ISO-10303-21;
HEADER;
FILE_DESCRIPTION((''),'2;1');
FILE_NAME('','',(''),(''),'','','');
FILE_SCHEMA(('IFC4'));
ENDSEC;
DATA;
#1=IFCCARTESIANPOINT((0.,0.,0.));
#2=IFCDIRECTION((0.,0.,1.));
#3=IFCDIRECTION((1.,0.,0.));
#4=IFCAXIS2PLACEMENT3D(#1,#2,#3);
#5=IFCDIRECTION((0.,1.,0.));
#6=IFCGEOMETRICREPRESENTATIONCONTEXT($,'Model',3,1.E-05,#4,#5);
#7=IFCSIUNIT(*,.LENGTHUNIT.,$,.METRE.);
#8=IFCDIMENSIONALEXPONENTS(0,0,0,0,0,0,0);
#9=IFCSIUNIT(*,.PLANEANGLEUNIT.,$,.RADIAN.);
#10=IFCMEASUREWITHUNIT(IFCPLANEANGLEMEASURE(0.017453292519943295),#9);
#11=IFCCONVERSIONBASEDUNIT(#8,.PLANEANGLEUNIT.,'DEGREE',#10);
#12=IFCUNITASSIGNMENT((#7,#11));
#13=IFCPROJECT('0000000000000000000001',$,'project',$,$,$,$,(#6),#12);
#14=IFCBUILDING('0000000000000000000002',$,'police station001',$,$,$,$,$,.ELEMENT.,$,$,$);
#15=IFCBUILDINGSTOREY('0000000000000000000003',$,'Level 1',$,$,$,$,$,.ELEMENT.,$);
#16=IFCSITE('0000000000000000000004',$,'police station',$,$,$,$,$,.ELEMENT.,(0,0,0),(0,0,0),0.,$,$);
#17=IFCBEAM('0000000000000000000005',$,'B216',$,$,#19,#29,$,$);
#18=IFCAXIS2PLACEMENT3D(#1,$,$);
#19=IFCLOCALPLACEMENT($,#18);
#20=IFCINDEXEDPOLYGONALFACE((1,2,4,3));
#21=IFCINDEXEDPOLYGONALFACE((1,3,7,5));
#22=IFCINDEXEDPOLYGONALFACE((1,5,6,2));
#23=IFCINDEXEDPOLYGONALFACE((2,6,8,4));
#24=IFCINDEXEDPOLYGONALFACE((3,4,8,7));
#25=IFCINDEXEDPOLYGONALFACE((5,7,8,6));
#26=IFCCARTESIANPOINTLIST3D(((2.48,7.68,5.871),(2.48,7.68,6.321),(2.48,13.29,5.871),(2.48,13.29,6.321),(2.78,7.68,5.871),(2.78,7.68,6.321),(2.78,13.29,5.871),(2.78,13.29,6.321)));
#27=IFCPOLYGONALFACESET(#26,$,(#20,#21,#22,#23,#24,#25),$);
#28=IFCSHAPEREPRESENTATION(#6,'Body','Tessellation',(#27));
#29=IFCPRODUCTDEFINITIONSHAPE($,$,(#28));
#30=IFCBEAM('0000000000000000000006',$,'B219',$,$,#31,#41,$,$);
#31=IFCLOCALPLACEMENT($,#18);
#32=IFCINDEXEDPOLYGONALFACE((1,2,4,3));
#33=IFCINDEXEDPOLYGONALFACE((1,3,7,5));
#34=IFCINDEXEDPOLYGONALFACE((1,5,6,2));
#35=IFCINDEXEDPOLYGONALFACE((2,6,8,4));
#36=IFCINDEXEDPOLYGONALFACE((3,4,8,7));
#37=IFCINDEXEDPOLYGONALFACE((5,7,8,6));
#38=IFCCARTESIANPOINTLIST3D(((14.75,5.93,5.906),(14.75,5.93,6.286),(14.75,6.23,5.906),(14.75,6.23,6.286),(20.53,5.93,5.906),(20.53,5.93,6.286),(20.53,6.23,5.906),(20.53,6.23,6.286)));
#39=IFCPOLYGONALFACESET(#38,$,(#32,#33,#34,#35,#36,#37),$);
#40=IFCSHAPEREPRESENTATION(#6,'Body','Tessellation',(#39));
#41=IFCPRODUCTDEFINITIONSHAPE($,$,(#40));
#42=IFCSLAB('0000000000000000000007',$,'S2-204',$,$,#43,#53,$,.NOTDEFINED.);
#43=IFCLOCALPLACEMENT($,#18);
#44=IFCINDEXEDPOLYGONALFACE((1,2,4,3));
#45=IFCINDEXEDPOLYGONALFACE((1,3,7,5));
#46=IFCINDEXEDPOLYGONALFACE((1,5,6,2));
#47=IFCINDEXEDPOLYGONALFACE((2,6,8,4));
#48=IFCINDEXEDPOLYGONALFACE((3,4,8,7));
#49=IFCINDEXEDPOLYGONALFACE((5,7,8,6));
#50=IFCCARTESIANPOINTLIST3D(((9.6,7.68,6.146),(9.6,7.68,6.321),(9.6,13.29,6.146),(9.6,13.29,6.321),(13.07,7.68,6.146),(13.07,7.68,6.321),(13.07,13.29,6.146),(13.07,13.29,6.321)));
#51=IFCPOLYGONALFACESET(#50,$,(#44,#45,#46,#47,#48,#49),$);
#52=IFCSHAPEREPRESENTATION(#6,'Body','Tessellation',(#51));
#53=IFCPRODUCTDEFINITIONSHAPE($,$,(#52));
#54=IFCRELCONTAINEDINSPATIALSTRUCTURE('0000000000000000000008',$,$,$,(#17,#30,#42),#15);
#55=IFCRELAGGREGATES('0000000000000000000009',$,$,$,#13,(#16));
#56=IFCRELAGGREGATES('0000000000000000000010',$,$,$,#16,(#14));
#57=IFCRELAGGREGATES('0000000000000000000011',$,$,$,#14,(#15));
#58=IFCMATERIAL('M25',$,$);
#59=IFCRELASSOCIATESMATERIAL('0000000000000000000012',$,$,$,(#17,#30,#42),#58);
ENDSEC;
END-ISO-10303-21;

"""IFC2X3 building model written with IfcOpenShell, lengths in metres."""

from ifc_helpers import new_model, entity, si_unit, converted_unit, direction, frame, frame_2d, origin_with_axes, place, context, project, spatial, rectangle, extrude, material, element, save


model = new_model("IFC2X3")

# Units and contexts
model_context = context("Model", 3, precision=1e-05, world=origin_with_axes(), true_north=direction((0.0, 1.0, 0.0)))
ifc_project = project(units=[si_unit("LENGTHUNIT", "METRE"), converted_unit("PLANEANGLEUNIT", "DEGREE", entity("IfcPlaneAngleMeasure", 0.017453292519943295), si_unit("PLANEANGLEUNIT", "RADIAN"), dimensions=[0, 0, 0, 0, 0, 0, 0])], contexts=[model_context])

# Site, building, storey
site = spatial("IfcSite", under=ifc_project, Name="police station", CompositionType="ELEMENT", RefLatitude=(0, 0, 0), RefLongitude=(0, 0, 0), RefElevation=0.0)
building = spatial("IfcBuilding", under=site, Name="police station001", CompositionType="ELEMENT")
storey = spatial("IfcBuildingStorey", under=building, Name="Level 1", CompositionType="ELEMENT")

# Shared definitions
ifc_material = material(Name="M25")
placement = place(None, origin_with_axes())

# Beams
element("IfcBeam", 1, at=placement, inside=storey, material=ifc_material, Name="B216", context=model_context, shape_type="SweptSolid", body=[
    extrude(rectangle(XDim=0.3, YDim=0.45, at=frame_2d((0.0, 0.0), x_axis=(0.0, 1.0, 0.0))), frame((2.63, 13.29, 6.096), z_axis=(0.0, -1.0, 0.0), x_axis=(0.0, 0.0, -1.0)), (0.0, 0.0, 1.0), 5.61),
])
element("IfcBeam", 2, at=placement, inside=storey, material=ifc_material, Name="B219", context=model_context, shape_type="SweptSolid", body=[
    extrude(rectangle(XDim=0.3, YDim=0.38, at=frame_2d((0.0, 0.0), x_axis=(0.0, 1.0, 0.0))), frame((20.53, 6.08, 6.096), z_axis=(-1.0, 0.0, 0.0), x_axis=(0.0, 0.0, -1.0)), (0.0, 0.0, 1.0), 5.78),
])

# Slab
element("IfcSlab", 3, at=placement, inside=storey, material=ifc_material, Name="S2-204", PredefinedType="NOTDEFINED", context=model_context, shape_type="SweptSolid", body=[
    extrude(rectangle(XDim=3.47, YDim=5.61, at=frame_2d((0.0, 0.0), x_axis=(1.0, 0.0, 0.0))), frame((11.335, 10.485, 6.146), z_axis=(0.0, 0.0, 1.0), x_axis=(1.0, 0.0, 0.0)), (0.0, 0.0, 1.0), 0.175),
])

save(model, "model.ifc")
